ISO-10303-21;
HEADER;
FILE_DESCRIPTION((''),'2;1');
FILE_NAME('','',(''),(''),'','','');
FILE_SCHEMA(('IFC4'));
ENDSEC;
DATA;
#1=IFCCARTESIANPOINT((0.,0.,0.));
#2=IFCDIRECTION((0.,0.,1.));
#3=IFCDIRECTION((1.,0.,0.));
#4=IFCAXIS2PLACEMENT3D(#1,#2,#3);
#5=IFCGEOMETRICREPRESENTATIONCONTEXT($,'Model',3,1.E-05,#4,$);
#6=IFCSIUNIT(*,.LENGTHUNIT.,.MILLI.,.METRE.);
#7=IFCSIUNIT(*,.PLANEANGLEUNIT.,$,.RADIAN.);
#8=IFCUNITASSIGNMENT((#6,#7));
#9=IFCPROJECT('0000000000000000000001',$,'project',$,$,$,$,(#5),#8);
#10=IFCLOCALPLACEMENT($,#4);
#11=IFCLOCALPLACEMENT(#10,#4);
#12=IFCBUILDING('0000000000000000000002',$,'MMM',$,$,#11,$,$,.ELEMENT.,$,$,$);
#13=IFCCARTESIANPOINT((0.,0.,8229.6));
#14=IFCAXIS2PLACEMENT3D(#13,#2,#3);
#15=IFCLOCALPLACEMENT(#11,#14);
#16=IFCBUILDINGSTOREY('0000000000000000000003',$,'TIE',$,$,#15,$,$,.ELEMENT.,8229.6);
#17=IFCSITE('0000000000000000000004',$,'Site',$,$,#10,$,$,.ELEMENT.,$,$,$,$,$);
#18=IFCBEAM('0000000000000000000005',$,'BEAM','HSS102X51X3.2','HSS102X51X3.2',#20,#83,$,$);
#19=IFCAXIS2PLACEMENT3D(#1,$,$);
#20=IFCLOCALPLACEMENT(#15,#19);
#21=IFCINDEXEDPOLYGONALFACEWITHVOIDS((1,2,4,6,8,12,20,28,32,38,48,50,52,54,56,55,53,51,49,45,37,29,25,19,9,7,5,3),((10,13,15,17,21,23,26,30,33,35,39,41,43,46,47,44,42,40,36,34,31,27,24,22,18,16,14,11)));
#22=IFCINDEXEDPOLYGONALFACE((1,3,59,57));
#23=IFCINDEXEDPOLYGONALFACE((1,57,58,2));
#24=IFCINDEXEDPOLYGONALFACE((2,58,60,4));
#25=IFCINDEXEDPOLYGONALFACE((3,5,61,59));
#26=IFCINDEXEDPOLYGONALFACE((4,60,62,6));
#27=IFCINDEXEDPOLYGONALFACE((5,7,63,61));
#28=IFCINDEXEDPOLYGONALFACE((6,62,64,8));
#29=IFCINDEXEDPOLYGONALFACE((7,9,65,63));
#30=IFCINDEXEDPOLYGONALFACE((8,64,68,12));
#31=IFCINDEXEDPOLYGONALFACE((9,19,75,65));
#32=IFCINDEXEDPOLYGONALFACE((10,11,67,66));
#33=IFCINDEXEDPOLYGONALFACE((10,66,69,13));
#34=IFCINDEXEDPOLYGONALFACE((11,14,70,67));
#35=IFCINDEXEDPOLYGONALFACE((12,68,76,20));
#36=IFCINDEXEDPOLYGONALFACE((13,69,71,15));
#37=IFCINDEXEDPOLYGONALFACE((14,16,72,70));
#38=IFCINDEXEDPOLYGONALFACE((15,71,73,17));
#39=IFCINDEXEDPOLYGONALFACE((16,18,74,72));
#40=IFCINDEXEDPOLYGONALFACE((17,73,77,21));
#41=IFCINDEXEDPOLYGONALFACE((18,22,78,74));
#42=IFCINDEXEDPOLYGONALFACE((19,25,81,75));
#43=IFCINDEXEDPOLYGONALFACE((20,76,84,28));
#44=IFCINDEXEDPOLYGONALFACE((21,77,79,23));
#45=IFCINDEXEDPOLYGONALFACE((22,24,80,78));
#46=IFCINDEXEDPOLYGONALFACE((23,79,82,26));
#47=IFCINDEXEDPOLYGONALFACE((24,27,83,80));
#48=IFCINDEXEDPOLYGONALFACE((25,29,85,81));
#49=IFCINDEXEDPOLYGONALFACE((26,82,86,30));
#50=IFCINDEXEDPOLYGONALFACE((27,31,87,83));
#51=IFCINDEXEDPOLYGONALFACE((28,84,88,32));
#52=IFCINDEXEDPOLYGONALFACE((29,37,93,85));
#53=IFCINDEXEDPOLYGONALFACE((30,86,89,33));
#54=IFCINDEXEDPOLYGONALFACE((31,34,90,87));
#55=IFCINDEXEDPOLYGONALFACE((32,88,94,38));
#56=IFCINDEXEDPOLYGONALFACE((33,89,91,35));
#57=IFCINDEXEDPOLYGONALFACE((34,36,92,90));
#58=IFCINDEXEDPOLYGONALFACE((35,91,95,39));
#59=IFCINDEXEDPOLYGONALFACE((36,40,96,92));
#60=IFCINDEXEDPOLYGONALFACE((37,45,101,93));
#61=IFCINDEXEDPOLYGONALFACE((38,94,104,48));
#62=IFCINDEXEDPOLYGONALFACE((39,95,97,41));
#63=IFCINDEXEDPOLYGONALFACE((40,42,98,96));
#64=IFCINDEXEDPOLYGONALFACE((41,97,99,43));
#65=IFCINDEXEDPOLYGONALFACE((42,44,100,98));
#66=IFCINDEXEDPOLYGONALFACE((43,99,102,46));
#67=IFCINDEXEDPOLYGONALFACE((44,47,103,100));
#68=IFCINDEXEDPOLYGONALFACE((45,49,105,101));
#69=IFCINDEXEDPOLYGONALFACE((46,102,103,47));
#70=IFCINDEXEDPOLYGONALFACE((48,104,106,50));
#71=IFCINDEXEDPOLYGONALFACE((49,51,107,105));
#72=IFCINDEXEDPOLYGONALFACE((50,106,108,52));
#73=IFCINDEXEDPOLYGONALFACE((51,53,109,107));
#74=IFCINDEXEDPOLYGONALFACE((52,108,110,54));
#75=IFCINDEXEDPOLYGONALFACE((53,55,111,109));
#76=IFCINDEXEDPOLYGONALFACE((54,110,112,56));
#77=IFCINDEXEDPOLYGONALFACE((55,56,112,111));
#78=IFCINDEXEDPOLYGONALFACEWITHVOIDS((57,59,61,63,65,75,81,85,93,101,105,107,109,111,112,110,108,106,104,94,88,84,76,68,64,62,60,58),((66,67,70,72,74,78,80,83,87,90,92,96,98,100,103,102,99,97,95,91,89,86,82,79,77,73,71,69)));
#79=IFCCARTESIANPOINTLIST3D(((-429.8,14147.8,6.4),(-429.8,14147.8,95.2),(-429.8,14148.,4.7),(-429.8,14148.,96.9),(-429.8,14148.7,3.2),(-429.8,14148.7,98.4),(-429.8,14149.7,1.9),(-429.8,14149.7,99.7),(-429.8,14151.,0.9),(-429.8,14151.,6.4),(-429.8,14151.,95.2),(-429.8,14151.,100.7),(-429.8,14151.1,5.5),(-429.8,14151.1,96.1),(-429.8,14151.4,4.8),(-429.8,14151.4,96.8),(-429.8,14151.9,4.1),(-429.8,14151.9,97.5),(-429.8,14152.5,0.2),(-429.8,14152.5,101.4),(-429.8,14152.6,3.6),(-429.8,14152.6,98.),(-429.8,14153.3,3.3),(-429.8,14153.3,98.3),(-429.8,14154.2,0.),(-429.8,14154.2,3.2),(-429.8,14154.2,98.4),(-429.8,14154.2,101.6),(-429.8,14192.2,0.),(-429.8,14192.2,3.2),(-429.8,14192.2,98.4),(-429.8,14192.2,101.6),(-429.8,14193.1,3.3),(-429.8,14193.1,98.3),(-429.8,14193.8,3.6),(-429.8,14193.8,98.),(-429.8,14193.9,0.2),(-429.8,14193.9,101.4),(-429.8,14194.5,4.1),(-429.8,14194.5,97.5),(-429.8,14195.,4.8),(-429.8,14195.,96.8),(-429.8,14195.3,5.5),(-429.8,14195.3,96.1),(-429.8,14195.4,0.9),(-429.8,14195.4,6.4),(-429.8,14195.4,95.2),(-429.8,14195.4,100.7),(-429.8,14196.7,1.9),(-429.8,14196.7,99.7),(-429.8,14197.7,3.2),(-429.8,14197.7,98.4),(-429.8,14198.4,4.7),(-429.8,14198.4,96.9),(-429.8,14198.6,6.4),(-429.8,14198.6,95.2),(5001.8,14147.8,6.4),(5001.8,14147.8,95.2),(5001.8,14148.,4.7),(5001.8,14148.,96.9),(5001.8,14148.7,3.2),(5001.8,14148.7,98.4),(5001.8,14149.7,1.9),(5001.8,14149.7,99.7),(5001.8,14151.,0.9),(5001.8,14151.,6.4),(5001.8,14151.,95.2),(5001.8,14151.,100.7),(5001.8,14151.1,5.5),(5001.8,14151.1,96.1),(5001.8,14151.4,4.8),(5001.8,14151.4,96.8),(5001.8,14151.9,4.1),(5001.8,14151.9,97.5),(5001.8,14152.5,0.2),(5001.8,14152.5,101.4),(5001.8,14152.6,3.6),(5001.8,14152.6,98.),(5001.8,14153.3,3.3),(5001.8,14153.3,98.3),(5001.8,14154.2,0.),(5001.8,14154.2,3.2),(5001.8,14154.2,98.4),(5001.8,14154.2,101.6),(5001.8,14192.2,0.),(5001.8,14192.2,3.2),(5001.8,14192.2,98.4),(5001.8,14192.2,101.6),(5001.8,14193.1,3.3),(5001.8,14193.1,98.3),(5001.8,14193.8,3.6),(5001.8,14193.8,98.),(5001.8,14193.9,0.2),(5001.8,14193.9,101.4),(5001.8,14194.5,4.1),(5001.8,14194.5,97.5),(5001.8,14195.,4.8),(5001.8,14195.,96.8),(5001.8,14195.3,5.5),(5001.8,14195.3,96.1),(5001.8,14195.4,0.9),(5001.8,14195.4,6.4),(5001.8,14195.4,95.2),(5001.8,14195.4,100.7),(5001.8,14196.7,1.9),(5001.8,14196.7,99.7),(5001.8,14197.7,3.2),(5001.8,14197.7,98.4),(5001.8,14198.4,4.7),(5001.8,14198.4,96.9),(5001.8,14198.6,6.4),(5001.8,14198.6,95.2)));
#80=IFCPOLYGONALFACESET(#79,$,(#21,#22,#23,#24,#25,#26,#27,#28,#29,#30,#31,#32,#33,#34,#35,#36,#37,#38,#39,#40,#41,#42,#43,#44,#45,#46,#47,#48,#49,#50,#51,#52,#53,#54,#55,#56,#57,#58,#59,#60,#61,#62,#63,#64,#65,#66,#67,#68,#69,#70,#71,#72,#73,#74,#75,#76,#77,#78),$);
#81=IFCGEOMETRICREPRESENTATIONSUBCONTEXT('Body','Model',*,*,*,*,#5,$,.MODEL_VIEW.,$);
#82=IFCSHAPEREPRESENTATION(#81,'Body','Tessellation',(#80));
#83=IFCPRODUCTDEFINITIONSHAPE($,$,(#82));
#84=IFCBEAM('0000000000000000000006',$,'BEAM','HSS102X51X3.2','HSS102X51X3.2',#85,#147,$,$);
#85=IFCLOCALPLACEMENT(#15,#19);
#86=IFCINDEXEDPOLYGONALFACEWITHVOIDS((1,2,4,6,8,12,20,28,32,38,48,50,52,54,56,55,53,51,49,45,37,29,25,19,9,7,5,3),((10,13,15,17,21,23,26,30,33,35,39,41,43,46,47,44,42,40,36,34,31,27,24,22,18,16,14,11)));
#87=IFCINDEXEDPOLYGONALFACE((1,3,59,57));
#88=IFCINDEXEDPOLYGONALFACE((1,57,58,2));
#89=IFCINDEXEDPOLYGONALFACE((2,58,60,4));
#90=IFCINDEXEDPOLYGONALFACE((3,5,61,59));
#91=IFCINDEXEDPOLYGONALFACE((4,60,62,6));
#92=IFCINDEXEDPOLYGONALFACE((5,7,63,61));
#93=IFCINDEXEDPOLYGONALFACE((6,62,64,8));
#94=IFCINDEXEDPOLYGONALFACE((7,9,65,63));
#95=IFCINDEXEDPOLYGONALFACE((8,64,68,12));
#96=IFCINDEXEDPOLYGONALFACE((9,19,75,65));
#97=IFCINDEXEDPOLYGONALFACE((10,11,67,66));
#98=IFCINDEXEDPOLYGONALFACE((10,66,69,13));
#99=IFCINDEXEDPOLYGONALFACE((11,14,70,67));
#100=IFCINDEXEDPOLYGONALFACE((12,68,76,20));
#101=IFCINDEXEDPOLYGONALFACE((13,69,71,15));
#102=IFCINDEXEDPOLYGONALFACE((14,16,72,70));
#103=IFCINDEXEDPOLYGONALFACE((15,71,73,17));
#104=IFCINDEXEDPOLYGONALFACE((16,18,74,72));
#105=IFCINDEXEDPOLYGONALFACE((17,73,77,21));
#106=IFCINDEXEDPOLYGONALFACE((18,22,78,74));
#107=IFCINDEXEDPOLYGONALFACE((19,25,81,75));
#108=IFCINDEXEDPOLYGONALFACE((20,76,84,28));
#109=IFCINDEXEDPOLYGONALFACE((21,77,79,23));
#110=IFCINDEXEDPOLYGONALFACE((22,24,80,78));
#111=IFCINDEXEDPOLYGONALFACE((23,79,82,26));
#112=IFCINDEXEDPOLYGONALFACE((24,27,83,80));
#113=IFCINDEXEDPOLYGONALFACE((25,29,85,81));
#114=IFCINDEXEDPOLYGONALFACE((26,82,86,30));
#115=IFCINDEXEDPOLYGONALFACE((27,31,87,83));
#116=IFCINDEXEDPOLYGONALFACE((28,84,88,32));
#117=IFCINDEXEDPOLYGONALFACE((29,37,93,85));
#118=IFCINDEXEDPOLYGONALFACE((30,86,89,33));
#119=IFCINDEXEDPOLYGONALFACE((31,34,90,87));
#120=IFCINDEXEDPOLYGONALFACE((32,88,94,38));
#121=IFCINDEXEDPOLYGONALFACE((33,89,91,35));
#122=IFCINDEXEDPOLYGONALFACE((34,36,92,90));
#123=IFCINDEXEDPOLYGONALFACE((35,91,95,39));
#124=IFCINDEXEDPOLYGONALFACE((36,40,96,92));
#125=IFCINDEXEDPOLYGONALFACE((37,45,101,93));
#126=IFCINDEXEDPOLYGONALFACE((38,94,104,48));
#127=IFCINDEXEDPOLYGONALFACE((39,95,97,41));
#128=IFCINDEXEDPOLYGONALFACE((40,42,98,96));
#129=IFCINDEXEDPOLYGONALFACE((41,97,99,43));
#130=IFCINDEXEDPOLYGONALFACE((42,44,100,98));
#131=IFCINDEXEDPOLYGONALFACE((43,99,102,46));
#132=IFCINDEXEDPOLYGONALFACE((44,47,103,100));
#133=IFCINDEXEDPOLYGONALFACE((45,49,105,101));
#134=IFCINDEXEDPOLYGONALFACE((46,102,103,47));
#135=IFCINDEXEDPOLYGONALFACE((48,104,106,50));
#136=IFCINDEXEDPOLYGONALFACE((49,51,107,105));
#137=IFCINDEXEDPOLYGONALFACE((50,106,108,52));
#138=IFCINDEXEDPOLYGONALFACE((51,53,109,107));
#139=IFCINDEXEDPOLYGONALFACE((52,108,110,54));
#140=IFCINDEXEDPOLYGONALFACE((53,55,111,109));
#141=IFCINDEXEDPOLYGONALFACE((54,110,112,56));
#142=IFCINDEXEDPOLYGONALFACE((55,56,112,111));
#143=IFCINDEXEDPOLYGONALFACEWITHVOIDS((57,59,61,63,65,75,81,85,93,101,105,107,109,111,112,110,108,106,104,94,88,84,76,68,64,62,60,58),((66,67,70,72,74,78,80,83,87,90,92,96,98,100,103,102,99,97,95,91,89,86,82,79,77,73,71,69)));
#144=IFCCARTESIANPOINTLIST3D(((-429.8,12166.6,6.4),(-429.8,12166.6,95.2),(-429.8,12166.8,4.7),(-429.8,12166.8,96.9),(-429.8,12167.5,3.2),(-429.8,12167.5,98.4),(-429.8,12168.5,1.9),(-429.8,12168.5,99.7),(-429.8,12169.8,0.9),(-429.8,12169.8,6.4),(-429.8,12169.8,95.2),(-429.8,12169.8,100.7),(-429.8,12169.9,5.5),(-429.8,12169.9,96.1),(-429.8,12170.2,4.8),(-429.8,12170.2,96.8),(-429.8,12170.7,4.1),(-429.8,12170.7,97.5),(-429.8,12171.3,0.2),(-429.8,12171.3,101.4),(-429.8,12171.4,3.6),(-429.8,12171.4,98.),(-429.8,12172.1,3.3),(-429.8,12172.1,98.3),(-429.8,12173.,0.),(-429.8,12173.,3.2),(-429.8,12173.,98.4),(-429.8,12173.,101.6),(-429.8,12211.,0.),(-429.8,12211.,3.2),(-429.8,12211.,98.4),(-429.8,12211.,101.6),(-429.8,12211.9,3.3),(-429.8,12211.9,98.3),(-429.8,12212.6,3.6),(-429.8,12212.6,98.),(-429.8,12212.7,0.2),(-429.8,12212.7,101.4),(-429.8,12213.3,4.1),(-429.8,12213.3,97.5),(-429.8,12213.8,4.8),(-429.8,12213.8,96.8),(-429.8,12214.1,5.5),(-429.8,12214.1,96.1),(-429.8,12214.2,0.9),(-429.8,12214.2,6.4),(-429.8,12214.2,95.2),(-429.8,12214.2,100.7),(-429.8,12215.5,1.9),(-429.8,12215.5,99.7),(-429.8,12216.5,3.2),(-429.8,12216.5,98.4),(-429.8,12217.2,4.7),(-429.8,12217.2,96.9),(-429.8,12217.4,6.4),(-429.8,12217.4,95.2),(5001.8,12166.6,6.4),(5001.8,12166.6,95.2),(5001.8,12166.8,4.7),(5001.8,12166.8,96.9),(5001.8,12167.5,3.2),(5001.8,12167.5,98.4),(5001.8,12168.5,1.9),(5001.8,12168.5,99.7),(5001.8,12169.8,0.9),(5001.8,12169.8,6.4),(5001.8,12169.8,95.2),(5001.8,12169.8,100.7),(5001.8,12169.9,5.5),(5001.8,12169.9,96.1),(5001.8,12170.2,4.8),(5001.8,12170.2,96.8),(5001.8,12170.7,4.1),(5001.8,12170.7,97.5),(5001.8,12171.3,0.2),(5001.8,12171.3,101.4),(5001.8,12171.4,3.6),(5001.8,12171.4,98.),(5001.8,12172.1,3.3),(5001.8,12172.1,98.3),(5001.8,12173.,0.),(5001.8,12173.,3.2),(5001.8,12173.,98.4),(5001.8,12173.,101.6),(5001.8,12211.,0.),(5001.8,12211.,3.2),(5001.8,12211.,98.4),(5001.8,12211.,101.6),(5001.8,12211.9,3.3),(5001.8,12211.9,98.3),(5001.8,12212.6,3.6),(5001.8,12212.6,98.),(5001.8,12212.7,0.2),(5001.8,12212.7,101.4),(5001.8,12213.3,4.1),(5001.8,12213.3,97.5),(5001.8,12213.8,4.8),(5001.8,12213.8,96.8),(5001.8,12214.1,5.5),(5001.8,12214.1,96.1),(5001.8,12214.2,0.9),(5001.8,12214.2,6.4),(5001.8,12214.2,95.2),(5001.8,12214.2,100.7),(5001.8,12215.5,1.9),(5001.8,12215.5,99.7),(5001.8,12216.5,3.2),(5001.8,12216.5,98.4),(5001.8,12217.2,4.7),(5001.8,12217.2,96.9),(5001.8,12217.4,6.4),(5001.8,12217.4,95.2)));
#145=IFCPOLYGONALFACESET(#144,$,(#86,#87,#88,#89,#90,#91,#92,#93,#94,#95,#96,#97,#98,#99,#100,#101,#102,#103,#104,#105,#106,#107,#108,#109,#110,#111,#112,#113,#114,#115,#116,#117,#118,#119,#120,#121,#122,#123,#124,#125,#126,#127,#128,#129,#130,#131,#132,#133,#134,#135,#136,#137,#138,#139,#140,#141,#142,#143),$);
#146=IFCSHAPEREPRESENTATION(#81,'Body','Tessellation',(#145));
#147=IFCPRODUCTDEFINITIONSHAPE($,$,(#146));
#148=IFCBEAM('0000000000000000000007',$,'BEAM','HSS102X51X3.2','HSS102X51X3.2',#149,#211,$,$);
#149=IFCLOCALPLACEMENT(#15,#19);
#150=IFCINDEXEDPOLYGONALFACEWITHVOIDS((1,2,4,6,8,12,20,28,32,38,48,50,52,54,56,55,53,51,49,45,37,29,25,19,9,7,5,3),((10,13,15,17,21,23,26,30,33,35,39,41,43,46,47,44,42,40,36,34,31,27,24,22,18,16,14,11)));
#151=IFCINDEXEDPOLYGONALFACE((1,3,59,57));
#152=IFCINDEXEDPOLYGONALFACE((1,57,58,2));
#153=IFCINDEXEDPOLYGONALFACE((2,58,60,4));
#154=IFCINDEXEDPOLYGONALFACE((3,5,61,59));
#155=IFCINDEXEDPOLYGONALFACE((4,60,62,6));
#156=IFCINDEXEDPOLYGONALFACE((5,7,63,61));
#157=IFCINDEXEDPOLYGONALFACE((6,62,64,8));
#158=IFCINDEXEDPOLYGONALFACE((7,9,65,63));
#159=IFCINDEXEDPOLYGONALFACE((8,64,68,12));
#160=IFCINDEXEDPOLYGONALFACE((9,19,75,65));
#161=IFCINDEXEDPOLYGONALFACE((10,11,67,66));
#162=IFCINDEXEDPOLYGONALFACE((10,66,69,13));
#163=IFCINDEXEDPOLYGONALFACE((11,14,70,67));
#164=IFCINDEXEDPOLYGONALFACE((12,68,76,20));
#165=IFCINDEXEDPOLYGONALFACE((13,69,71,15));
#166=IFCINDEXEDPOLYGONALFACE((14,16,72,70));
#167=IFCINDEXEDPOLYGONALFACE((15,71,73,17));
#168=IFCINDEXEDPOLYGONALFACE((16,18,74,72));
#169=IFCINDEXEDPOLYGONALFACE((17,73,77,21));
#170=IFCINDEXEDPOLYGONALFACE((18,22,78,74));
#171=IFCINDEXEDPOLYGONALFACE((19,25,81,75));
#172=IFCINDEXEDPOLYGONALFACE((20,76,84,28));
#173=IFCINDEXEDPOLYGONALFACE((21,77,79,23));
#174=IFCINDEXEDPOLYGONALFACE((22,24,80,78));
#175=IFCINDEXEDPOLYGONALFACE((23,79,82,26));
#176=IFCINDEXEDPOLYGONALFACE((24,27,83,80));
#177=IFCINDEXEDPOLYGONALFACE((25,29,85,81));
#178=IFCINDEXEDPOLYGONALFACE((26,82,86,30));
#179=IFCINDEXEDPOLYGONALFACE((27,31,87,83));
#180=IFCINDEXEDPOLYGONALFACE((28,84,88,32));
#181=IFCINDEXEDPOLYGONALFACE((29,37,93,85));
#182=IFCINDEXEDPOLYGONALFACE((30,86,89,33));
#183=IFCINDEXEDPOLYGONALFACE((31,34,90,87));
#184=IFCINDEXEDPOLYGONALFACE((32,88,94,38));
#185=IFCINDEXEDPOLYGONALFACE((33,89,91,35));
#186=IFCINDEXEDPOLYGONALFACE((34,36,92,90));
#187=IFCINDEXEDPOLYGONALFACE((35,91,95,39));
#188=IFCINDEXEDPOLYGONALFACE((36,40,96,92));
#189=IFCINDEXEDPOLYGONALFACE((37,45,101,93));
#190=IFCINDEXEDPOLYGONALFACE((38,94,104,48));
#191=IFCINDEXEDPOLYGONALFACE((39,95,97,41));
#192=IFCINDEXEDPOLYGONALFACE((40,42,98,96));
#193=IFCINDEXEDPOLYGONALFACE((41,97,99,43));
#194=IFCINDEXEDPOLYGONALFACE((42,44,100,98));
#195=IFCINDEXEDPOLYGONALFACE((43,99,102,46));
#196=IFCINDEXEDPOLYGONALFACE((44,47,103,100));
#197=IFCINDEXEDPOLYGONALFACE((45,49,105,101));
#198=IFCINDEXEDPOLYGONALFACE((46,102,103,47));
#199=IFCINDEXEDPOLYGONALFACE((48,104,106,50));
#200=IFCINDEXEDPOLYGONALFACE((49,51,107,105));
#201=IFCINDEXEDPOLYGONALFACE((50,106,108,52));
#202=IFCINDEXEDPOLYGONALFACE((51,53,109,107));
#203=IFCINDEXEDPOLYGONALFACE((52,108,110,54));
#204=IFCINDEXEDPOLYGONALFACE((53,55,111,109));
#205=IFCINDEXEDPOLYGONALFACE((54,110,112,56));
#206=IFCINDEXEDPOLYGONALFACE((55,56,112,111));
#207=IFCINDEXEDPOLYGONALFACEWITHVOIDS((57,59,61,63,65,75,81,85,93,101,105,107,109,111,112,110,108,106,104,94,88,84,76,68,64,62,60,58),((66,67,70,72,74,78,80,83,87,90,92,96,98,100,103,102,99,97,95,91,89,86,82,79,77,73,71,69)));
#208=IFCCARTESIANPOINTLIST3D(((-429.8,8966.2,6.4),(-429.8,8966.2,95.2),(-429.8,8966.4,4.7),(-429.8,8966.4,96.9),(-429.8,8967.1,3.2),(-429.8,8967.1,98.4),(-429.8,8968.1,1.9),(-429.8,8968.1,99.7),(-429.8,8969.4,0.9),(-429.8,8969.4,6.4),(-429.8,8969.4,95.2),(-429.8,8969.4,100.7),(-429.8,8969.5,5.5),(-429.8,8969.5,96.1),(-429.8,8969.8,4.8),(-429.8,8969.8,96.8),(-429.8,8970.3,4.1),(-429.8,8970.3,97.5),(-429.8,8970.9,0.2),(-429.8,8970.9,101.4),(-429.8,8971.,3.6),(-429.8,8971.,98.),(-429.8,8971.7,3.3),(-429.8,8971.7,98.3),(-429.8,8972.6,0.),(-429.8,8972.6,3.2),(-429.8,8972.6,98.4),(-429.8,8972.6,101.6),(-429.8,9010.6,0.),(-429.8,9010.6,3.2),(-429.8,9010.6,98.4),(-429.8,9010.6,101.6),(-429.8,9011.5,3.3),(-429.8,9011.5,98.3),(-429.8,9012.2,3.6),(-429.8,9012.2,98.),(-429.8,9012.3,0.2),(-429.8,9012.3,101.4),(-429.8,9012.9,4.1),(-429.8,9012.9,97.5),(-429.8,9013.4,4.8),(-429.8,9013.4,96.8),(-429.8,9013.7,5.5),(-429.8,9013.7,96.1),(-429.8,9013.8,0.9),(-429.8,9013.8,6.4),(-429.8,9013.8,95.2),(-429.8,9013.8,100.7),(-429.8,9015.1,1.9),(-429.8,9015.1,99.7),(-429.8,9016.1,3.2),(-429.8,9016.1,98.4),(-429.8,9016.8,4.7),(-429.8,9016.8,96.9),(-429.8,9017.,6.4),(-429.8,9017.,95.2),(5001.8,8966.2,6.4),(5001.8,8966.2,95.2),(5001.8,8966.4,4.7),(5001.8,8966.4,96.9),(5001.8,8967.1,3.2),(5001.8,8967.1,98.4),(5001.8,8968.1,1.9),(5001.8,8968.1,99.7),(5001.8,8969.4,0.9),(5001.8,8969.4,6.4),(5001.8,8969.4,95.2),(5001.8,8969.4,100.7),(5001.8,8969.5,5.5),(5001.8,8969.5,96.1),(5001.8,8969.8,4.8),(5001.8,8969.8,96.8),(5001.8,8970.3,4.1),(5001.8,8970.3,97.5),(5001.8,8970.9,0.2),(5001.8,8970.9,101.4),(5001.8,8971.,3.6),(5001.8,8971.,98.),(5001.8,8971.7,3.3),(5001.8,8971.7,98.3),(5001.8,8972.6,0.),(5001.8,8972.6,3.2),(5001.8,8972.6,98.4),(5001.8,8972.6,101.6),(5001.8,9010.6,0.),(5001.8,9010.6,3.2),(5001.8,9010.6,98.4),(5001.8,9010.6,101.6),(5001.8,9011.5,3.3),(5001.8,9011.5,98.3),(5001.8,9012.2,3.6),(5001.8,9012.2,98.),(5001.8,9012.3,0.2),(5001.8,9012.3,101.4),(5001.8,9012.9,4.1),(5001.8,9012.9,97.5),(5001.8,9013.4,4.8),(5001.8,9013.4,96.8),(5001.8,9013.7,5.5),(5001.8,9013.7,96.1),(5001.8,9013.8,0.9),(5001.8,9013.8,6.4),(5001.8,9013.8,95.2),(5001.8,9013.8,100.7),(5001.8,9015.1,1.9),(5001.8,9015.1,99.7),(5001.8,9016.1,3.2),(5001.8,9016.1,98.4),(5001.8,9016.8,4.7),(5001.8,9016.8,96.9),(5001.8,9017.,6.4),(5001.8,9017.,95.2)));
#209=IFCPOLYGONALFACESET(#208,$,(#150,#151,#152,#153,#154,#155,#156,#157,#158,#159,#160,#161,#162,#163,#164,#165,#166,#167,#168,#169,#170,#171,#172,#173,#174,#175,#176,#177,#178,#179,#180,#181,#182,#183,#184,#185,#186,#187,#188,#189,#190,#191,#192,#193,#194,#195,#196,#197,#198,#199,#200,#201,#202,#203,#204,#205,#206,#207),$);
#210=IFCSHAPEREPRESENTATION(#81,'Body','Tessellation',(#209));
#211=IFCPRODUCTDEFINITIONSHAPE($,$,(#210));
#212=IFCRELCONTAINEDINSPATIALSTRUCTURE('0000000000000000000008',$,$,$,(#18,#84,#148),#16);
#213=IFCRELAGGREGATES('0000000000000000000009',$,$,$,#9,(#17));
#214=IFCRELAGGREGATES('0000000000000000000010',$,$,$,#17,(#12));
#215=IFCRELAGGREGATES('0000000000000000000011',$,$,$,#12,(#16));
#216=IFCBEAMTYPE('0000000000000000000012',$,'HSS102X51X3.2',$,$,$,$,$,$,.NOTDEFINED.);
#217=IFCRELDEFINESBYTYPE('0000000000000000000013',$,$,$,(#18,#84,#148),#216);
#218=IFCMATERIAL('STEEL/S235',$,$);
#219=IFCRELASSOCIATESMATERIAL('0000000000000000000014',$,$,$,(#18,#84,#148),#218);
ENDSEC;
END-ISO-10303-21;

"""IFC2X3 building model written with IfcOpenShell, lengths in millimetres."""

from ifc_helpers import new_model, si_unit, frame, origin_with_axes, origin_2d_with_axis, place, context, subcontext, project, spatial, hollow_rectangle, extrude, material, type_object, element, save


model = new_model("IFC2X3")

# Units and contexts
model_context = context("Model", 3, precision=1e-05, world=origin_with_axes())
body_context = subcontext(model_context, "Body", "Model", "MODEL_VIEW")
ifc_project = project(units=[si_unit("LENGTHUNIT", "METRE", prefix="MILLI"), si_unit("PLANEANGLEUNIT", "RADIAN")], contexts=[model_context])

# Site, building, storey
site_placement = place(None, origin_with_axes())
site = spatial("IfcSite", under=ifc_project, at=site_placement, Name="Site", CompositionType="ELEMENT")
building_placement = place(site_placement, origin_with_axes())
building = spatial("IfcBuilding", under=site, at=building_placement, Name="MMM", CompositionType="ELEMENT")
storey_placement = place(building_placement, frame((0.0, 0.0, 8229.6), z_axis=(0.0, 0.0, 1.0), x_axis=(1.0, 0.0, 0.0)))
storey = spatial("IfcBuildingStorey", under=building, at=storey_placement, Name="TIE", CompositionType="ELEMENT", Elevation=8229.6)

# Shared definitions
ifc_material = material(Name="STEEL/S235")

# Beams
beam_type_1 = type_object("IfcBeamType", Name="HSS102X51X3.2", PredefinedType="NOTDEFINED")
for number, where, z_axis, x_axis, name in (
    (1, (-429.8, 14173.2, 50.8), (0.0, 0.0, 1.0), (1.0, 0.0, 0.0), "BEAM"),
    (2, (-429.8, 12192.0, 50.8), (0.0, 0.0, 1.0), (1.0, 0.0, 0.0), "BEAM"),
    (3, (-429.8, 8991.6, 50.8), (0.0, 0.0, 1.0), (1.0, 0.0, 0.0), "BEAM"),
):
    element("IfcBeam", number, at=place(storey_placement, frame(where, z_axis=z_axis, x_axis=x_axis)), inside=storey, type_object=beam_type_1, material=ifc_material, Name=name, Description="HSS102X51X3.2", ObjectType="HSS102X51X3.2", context=body_context, shape_type="SweptSolid", body=[
        extrude(hollow_rectangle(XDim=50.8, YDim=101.6, WallThickness=3.2, InnerFilletRadius=3.2, OuterFilletRadius=6.4, at=origin_2d_with_axis()), frame((5431.6, 0.0, 0.0), z_axis=(-1.0, 0.0, 0.0), x_axis=(0.0, -1.0, 0.0)), (0.0, 0.0, 1.0), 5431.6),
    ])

save(model, "model.ifc")
